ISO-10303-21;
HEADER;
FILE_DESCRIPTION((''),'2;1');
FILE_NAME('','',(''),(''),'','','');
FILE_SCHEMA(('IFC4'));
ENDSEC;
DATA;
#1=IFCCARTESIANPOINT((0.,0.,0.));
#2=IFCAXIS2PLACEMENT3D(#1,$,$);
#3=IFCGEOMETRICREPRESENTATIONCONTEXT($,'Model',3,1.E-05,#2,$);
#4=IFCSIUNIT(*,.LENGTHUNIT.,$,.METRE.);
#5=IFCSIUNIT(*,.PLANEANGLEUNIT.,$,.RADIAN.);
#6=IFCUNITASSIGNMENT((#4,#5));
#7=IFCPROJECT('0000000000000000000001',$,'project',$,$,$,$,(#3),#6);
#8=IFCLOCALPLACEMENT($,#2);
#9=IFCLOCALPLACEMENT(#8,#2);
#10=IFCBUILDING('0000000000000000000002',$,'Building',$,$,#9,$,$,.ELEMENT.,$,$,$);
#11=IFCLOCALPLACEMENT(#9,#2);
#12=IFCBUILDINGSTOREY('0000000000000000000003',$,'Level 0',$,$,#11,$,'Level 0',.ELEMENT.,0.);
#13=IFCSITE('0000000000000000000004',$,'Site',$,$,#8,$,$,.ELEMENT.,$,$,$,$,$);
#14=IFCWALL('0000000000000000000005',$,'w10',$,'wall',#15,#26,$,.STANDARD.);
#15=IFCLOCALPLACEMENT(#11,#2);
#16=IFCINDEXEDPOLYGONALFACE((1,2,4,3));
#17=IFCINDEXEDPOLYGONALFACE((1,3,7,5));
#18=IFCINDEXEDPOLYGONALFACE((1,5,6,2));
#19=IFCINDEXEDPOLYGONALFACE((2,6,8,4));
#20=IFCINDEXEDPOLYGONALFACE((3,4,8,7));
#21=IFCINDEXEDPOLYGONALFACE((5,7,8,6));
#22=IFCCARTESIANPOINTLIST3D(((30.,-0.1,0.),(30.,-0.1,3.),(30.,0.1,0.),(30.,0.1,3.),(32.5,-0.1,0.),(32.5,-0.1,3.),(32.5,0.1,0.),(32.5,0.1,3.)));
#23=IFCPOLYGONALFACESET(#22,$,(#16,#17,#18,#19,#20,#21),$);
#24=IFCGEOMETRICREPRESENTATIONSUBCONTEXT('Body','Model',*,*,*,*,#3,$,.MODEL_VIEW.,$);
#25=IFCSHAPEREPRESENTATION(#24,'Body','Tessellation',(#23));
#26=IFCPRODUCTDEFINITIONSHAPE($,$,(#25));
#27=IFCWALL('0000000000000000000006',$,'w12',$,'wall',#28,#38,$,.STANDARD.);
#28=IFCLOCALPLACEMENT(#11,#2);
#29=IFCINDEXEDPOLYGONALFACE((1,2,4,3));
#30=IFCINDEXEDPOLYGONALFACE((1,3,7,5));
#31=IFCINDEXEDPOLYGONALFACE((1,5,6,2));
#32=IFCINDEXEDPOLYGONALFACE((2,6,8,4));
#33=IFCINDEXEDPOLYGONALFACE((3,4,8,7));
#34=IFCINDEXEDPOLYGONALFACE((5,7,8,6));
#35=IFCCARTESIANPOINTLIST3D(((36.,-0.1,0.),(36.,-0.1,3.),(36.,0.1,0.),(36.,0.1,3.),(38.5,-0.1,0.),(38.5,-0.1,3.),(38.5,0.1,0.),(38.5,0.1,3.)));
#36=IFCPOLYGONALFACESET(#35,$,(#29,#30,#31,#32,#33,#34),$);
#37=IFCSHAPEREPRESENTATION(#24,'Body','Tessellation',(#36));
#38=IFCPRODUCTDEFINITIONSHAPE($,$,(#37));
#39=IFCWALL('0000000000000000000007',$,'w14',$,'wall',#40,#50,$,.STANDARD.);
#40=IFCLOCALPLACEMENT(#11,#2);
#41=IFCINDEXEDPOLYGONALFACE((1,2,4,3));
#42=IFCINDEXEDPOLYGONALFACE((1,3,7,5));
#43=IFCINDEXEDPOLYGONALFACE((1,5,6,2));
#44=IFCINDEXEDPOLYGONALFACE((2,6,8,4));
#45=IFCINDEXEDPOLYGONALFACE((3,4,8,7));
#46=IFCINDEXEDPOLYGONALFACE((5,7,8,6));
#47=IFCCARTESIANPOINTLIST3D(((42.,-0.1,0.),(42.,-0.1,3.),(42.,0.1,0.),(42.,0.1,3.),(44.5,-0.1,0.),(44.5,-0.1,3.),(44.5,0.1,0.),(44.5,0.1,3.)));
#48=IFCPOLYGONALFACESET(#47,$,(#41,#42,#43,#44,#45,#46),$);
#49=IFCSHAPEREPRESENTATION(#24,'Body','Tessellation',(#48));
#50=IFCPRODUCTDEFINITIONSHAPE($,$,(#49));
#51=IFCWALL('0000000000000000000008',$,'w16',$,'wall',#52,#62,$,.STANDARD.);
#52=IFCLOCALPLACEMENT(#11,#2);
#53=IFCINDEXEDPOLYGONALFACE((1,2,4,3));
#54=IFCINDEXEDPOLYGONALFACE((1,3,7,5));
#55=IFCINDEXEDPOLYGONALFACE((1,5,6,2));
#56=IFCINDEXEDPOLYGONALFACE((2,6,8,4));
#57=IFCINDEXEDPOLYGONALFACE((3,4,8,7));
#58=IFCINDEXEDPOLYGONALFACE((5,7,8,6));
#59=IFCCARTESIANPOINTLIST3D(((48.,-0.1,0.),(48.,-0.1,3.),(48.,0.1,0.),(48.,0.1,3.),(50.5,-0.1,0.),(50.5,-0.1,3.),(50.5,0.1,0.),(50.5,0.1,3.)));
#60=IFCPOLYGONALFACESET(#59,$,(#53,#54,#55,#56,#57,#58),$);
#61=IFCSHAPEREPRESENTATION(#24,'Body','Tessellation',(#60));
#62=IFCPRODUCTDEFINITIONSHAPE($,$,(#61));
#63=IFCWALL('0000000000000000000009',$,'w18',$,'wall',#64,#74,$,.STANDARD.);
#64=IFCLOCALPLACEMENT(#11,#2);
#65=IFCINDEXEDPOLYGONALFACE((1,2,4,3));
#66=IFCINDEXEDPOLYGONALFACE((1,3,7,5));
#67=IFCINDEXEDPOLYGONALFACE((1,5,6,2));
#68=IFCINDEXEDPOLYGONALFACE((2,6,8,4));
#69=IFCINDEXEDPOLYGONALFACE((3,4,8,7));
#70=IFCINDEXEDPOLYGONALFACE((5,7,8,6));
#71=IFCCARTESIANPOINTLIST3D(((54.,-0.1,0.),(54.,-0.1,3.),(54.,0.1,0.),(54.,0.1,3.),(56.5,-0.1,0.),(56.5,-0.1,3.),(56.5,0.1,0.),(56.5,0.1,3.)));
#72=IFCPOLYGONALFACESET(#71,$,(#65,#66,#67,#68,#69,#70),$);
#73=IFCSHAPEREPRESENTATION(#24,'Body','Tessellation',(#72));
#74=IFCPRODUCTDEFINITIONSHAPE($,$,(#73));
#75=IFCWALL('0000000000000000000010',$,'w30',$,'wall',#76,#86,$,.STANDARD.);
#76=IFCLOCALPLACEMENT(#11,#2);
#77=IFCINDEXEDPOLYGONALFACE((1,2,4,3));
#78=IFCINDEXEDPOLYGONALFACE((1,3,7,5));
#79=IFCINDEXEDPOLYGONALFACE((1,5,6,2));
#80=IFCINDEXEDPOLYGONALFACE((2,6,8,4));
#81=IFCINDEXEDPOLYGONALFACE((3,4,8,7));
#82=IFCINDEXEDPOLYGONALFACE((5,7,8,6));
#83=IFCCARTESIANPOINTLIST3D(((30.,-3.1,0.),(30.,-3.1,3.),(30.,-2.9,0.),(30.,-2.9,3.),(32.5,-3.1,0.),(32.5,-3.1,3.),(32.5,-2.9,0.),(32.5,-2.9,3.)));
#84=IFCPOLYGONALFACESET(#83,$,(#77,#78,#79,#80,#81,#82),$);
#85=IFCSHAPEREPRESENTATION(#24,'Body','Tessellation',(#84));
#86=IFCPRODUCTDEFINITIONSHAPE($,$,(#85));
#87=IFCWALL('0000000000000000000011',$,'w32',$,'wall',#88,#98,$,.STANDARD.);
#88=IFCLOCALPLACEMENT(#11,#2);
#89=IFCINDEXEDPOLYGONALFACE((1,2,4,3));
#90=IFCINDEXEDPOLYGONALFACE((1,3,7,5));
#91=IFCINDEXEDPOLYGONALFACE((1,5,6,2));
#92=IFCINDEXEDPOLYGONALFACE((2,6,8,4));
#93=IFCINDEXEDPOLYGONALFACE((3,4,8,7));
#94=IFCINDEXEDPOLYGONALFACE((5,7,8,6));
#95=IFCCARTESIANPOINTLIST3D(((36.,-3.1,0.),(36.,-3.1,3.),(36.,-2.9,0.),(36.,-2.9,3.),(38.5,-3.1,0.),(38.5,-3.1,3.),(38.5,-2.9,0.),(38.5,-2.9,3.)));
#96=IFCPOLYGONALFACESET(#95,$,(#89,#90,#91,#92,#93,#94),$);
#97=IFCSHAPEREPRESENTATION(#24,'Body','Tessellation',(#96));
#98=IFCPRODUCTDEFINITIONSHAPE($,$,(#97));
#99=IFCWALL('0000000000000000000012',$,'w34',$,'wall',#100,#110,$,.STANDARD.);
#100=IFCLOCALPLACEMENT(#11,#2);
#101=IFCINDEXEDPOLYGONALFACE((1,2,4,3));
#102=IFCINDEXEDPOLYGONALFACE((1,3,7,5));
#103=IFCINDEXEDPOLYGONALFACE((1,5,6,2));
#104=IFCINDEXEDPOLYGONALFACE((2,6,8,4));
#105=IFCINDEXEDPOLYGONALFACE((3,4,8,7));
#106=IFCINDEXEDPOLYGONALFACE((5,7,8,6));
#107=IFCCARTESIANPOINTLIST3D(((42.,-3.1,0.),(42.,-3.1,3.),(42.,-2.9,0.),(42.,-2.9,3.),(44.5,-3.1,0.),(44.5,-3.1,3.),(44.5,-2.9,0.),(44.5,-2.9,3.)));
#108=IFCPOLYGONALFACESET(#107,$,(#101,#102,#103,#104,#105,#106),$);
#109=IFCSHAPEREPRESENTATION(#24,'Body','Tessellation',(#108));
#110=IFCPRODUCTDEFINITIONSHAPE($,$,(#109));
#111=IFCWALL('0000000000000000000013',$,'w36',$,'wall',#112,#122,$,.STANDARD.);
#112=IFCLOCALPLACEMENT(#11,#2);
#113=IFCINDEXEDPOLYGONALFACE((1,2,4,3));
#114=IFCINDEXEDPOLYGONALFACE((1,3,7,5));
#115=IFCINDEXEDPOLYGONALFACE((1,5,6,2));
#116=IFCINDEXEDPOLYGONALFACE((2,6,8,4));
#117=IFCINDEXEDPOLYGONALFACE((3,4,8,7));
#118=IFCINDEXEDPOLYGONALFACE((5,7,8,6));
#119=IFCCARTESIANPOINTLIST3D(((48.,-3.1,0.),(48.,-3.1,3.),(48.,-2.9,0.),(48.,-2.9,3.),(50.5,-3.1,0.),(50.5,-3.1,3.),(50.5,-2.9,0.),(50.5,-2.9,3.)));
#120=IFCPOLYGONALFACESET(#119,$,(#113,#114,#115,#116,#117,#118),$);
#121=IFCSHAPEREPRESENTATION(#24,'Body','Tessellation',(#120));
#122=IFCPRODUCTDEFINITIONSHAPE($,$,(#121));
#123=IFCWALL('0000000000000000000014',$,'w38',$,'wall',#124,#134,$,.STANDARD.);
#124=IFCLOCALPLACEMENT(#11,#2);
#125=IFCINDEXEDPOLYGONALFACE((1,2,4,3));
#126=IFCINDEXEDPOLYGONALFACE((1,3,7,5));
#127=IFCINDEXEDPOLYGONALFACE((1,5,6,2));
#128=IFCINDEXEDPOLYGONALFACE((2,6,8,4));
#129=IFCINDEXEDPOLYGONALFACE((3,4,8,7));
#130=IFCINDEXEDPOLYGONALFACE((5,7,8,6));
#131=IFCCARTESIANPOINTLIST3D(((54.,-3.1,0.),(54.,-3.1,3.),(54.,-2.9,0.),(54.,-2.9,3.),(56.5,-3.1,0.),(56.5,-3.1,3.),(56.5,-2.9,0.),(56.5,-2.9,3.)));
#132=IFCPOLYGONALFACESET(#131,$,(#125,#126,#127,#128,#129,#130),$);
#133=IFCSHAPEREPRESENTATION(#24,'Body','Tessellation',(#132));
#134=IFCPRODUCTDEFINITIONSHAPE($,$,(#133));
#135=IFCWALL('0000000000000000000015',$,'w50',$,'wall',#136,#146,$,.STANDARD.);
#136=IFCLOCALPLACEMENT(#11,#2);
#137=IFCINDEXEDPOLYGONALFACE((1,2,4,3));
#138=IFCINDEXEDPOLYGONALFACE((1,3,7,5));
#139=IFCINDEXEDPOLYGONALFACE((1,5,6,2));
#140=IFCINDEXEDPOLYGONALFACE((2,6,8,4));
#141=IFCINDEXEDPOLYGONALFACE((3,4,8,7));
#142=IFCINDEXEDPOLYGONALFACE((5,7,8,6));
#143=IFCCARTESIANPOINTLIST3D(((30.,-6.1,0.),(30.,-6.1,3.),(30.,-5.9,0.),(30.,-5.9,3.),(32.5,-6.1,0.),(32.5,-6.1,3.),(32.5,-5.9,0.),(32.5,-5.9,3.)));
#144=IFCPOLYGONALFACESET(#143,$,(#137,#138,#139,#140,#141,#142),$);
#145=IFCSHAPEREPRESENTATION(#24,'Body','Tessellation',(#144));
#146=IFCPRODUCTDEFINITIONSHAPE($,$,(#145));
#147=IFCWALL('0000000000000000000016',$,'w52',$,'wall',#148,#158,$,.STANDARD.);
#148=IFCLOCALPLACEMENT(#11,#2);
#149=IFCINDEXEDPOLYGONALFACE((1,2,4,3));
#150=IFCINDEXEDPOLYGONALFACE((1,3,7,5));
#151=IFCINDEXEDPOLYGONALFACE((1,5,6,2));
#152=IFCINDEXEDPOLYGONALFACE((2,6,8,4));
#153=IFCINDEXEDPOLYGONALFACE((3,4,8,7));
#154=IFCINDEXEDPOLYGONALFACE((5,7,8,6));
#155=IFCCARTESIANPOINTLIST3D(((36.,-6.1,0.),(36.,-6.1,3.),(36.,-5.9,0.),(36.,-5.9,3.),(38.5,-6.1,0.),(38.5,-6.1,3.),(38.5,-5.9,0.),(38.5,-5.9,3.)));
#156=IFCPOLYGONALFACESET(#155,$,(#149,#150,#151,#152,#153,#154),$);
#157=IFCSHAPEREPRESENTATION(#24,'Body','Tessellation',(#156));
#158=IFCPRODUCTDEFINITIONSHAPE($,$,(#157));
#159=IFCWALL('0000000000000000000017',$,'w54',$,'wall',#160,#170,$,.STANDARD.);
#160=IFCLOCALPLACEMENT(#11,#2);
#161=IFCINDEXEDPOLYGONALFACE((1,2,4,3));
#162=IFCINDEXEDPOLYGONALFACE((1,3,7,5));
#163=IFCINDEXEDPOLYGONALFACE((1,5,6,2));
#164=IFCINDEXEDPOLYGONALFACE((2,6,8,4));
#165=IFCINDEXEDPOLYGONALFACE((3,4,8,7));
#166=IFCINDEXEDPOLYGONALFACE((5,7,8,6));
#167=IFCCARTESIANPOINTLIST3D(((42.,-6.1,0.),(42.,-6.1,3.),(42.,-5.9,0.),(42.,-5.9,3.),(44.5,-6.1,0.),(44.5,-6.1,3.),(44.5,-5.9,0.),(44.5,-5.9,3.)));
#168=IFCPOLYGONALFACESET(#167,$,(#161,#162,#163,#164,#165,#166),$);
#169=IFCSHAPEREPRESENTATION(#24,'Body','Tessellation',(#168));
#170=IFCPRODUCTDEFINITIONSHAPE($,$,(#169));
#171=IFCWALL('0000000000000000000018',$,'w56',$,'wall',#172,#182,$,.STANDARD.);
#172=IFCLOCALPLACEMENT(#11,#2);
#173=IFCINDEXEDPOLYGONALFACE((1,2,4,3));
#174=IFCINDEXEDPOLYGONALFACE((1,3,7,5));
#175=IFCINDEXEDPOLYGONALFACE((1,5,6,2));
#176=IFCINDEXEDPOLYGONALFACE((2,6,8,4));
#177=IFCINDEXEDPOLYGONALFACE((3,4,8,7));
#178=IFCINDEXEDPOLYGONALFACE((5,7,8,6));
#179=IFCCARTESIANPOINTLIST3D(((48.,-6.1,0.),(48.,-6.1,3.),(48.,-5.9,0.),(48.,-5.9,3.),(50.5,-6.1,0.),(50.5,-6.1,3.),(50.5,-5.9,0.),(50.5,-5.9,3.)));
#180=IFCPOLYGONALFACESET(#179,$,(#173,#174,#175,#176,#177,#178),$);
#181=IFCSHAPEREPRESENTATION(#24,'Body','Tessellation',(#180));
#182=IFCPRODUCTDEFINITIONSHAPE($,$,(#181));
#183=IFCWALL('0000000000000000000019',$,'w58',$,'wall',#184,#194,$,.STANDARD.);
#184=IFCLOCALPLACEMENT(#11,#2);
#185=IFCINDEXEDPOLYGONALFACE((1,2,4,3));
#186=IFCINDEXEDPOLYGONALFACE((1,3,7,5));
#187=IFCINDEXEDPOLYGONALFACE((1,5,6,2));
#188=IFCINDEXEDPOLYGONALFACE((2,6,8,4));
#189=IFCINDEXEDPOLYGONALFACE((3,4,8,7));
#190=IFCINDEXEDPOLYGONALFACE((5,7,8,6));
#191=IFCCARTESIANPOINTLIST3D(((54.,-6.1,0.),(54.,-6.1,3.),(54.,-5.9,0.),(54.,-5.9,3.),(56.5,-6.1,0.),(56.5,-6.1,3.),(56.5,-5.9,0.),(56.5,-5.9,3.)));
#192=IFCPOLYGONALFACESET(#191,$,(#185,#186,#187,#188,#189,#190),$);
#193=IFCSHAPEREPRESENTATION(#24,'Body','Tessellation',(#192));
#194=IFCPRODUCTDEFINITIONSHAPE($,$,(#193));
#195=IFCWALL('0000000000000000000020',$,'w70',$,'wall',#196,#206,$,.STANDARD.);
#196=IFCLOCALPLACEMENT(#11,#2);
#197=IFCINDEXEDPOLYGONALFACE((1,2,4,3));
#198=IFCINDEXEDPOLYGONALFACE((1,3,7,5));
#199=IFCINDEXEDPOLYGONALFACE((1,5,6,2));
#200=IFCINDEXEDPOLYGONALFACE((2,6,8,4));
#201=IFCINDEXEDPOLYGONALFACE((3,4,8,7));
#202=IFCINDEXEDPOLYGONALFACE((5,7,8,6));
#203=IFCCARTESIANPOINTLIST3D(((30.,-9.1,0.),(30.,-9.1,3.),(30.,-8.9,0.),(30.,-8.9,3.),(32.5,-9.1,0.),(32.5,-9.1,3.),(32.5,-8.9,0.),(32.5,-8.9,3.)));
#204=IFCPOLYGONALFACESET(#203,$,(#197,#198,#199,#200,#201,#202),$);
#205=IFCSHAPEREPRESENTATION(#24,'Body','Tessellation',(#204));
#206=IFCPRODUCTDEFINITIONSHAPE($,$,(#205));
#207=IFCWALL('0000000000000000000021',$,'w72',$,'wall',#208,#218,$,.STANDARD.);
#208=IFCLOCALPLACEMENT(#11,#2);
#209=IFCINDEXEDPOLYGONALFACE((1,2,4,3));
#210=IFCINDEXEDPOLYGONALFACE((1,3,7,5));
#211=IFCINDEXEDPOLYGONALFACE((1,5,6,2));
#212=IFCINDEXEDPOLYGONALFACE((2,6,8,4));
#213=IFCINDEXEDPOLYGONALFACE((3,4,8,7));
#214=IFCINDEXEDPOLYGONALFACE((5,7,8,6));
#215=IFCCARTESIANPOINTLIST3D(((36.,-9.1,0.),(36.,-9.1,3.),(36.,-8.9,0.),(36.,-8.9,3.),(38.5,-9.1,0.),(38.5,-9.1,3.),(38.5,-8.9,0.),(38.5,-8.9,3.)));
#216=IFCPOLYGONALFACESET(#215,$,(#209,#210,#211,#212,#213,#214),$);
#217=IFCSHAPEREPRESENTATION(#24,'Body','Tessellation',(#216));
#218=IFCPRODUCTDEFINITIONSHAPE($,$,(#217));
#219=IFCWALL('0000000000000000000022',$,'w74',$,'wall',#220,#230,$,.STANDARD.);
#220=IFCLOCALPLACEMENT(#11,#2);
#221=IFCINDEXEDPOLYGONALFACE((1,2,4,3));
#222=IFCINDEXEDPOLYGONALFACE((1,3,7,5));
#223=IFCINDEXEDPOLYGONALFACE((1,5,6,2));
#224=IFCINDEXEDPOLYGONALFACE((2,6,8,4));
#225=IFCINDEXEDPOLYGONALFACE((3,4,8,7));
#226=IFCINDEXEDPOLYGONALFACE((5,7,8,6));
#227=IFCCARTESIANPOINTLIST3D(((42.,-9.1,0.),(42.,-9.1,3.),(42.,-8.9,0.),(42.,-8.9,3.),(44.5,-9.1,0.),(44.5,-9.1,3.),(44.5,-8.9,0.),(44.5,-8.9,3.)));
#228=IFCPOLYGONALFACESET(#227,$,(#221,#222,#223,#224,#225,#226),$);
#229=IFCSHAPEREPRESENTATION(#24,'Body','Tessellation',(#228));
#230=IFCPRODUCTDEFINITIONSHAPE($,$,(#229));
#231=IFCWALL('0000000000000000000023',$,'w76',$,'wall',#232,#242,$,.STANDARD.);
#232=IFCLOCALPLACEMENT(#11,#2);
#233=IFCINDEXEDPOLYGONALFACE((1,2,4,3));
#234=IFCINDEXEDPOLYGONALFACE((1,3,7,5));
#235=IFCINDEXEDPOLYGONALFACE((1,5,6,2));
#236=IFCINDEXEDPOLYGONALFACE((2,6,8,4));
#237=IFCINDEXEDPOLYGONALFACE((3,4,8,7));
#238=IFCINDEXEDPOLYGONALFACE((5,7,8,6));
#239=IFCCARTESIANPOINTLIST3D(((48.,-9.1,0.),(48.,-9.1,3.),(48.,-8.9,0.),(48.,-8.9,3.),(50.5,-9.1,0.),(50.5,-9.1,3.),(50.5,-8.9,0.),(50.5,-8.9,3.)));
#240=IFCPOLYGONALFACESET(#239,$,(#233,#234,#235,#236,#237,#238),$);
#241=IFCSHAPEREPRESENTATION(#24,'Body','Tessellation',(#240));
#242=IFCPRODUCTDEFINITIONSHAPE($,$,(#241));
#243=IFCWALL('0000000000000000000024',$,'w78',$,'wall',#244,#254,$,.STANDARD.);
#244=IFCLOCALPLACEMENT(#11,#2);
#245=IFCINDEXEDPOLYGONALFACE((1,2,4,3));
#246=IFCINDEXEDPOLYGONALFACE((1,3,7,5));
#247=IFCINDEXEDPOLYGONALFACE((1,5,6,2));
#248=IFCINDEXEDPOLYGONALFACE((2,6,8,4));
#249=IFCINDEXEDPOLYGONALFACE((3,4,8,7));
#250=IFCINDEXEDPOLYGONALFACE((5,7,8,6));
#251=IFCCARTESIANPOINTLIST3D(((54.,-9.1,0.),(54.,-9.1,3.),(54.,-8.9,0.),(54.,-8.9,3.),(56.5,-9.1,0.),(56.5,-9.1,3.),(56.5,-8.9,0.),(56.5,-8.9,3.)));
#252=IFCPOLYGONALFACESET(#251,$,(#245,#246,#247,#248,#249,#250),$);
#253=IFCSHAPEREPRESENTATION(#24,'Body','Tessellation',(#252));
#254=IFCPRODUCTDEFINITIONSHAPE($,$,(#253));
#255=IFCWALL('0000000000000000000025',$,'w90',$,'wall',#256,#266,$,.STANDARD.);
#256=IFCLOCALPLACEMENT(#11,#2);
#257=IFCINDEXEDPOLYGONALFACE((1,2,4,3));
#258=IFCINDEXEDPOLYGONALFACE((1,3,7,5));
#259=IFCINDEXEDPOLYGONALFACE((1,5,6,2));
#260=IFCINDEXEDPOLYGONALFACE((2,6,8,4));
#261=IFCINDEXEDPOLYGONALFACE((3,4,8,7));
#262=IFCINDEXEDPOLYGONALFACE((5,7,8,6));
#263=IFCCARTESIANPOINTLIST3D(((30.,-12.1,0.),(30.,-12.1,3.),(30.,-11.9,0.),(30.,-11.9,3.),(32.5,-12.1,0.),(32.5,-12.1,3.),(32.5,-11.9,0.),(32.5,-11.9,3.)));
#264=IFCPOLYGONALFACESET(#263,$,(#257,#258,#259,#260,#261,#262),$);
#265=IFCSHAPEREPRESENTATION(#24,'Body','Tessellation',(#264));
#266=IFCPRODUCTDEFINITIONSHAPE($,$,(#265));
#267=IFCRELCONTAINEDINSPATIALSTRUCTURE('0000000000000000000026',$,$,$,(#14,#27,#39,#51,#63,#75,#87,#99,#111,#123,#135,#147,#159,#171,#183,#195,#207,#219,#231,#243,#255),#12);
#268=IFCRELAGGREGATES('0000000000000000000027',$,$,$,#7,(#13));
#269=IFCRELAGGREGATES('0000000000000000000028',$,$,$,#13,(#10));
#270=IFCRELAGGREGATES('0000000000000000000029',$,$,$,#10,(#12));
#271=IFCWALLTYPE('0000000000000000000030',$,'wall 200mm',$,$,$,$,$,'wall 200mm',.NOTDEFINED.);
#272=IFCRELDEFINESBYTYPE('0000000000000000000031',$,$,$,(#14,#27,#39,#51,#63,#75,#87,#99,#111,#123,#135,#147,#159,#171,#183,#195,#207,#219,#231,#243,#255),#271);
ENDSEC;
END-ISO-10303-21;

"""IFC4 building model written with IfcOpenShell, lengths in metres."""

from ifc_helpers import new_model, si_unit, frame, frame_2d, origin, place, context, subcontext, project, spatial, rectangle, extrude, type_object, element, save


model = new_model("IFC4")

# Units and contexts
model_context = context("Model", 3, precision=1e-05, world=origin())
body_context = subcontext(model_context, "Body", "Model", "MODEL_VIEW")
ifc_project = project(units=[si_unit("LENGTHUNIT", "METRE"), si_unit("PLANEANGLEUNIT", "RADIAN")], contexts=[model_context])

# Site, building, storey
site_placement = place(None, origin())
site = spatial("IfcSite", under=ifc_project, at=site_placement, Name="Site", CompositionType="ELEMENT")
building_placement = place(site_placement, origin())
building = spatial("IfcBuilding", under=site, at=building_placement, Name="Building", CompositionType="ELEMENT")
storey_placement = place(building_placement, origin())
storey = spatial("IfcBuildingStorey", under=building, at=storey_placement, Name="Level 0", LongName="Level 0", CompositionType="ELEMENT", Elevation=0.0)

# Walls
wall_type = type_object("IfcWallType", Name="wall 200mm", ElementType="wall 200mm", PredefinedType="NOTDEFINED")
for number, where, z_axis, x_axis, name in (
    (1, (30.0, 0.0, 0.0), (0.0, 0.0, 1.0), (1.0, 0.0, 0.0), "w10"),
    (2, (36.0, 0.0, 0.0), (0.0, 0.0, 1.0), (1.0, 0.0, 0.0), "w12"),
    (3, (42.0, 0.0, 0.0), (0.0, 0.0, 1.0), (1.0, 0.0, 0.0), "w14"),
    (4, (48.0, 0.0, 0.0), (0.0, 0.0, 1.0), (1.0, 0.0, 0.0), "w16"),
    (5, (54.0, 0.0, 0.0), (0.0, 0.0, 1.0), (1.0, 0.0, 0.0), "w18"),
    (6, (30.0, -3.0, 0.0), (0.0, 0.0, 1.0), (1.0, 0.0, 0.0), "w30"),
    (7, (36.0, -3.0, 0.0), (0.0, 0.0, 1.0), (1.0, 0.0, 0.0), "w32"),
    (8, (42.0, -3.0, 0.0), (0.0, 0.0, 1.0), (1.0, 0.0, 0.0), "w34"),
    (9, (48.0, -3.0, 0.0), (0.0, 0.0, 1.0), (1.0, 0.0, 0.0), "w36"),
    (10, (54.0, -3.0, 0.0), (0.0, 0.0, 1.0), (1.0, 0.0, 0.0), "w38"),
    (11, (30.0, -6.0, 0.0), (0.0, 0.0, 1.0), (1.0, 0.0, 0.0), "w50"),
    (12, (36.0, -6.0, 0.0), (0.0, 0.0, 1.0), (1.0, 0.0, 0.0), "w52"),
    (13, (42.0, -6.0, 0.0), (0.0, 0.0, 1.0), (1.0, 0.0, 0.0), "w54"),
    (14, (48.0, -6.0, 0.0), (0.0, 0.0, 1.0), (1.0, 0.0, 0.0), "w56"),
    (15, (54.0, -6.0, 0.0), (0.0, 0.0, 1.0), (1.0, 0.0, 0.0), "w58"),
    (16, (30.0, -9.0, 0.0), (0.0, 0.0, 1.0), (1.0, 0.0, 0.0), "w70"),
    (17, (36.0, -9.0, 0.0), (0.0, 0.0, 1.0), (1.0, 0.0, 0.0), "w72"),
    (18, (42.0, -9.0, 0.0), (0.0, 0.0, 1.0), (1.0, 0.0, 0.0), "w74"),
    (19, (48.0, -9.0, 0.0), (0.0, 0.0, 1.0), (1.0, 0.0, 0.0), "w76"),
    (20, (54.0, -9.0, 0.0), (0.0, 0.0, 1.0), (1.0, 0.0, 0.0), "w78"),
    (21, (30.0, -12.0, 0.0), (0.0, 0.0, 1.0), (1.0, 0.0, 0.0), "w90"),
):
    element("IfcWall", number, at=place(storey_placement, frame(where, z_axis=z_axis, x_axis=x_axis)), inside=storey, type_object=wall_type, Name=name, ObjectType="wall", PredefinedType="STANDARD", context=body_context, shape_type="SweptSolid", body=[
        extrude(rectangle(XDim=2.5, YDim=0.2, at=frame_2d((1.25, 0.0))), origin(), (0.0, 0.0, 1.0), 3.0),
    ])

save(model, "model.ifc")
